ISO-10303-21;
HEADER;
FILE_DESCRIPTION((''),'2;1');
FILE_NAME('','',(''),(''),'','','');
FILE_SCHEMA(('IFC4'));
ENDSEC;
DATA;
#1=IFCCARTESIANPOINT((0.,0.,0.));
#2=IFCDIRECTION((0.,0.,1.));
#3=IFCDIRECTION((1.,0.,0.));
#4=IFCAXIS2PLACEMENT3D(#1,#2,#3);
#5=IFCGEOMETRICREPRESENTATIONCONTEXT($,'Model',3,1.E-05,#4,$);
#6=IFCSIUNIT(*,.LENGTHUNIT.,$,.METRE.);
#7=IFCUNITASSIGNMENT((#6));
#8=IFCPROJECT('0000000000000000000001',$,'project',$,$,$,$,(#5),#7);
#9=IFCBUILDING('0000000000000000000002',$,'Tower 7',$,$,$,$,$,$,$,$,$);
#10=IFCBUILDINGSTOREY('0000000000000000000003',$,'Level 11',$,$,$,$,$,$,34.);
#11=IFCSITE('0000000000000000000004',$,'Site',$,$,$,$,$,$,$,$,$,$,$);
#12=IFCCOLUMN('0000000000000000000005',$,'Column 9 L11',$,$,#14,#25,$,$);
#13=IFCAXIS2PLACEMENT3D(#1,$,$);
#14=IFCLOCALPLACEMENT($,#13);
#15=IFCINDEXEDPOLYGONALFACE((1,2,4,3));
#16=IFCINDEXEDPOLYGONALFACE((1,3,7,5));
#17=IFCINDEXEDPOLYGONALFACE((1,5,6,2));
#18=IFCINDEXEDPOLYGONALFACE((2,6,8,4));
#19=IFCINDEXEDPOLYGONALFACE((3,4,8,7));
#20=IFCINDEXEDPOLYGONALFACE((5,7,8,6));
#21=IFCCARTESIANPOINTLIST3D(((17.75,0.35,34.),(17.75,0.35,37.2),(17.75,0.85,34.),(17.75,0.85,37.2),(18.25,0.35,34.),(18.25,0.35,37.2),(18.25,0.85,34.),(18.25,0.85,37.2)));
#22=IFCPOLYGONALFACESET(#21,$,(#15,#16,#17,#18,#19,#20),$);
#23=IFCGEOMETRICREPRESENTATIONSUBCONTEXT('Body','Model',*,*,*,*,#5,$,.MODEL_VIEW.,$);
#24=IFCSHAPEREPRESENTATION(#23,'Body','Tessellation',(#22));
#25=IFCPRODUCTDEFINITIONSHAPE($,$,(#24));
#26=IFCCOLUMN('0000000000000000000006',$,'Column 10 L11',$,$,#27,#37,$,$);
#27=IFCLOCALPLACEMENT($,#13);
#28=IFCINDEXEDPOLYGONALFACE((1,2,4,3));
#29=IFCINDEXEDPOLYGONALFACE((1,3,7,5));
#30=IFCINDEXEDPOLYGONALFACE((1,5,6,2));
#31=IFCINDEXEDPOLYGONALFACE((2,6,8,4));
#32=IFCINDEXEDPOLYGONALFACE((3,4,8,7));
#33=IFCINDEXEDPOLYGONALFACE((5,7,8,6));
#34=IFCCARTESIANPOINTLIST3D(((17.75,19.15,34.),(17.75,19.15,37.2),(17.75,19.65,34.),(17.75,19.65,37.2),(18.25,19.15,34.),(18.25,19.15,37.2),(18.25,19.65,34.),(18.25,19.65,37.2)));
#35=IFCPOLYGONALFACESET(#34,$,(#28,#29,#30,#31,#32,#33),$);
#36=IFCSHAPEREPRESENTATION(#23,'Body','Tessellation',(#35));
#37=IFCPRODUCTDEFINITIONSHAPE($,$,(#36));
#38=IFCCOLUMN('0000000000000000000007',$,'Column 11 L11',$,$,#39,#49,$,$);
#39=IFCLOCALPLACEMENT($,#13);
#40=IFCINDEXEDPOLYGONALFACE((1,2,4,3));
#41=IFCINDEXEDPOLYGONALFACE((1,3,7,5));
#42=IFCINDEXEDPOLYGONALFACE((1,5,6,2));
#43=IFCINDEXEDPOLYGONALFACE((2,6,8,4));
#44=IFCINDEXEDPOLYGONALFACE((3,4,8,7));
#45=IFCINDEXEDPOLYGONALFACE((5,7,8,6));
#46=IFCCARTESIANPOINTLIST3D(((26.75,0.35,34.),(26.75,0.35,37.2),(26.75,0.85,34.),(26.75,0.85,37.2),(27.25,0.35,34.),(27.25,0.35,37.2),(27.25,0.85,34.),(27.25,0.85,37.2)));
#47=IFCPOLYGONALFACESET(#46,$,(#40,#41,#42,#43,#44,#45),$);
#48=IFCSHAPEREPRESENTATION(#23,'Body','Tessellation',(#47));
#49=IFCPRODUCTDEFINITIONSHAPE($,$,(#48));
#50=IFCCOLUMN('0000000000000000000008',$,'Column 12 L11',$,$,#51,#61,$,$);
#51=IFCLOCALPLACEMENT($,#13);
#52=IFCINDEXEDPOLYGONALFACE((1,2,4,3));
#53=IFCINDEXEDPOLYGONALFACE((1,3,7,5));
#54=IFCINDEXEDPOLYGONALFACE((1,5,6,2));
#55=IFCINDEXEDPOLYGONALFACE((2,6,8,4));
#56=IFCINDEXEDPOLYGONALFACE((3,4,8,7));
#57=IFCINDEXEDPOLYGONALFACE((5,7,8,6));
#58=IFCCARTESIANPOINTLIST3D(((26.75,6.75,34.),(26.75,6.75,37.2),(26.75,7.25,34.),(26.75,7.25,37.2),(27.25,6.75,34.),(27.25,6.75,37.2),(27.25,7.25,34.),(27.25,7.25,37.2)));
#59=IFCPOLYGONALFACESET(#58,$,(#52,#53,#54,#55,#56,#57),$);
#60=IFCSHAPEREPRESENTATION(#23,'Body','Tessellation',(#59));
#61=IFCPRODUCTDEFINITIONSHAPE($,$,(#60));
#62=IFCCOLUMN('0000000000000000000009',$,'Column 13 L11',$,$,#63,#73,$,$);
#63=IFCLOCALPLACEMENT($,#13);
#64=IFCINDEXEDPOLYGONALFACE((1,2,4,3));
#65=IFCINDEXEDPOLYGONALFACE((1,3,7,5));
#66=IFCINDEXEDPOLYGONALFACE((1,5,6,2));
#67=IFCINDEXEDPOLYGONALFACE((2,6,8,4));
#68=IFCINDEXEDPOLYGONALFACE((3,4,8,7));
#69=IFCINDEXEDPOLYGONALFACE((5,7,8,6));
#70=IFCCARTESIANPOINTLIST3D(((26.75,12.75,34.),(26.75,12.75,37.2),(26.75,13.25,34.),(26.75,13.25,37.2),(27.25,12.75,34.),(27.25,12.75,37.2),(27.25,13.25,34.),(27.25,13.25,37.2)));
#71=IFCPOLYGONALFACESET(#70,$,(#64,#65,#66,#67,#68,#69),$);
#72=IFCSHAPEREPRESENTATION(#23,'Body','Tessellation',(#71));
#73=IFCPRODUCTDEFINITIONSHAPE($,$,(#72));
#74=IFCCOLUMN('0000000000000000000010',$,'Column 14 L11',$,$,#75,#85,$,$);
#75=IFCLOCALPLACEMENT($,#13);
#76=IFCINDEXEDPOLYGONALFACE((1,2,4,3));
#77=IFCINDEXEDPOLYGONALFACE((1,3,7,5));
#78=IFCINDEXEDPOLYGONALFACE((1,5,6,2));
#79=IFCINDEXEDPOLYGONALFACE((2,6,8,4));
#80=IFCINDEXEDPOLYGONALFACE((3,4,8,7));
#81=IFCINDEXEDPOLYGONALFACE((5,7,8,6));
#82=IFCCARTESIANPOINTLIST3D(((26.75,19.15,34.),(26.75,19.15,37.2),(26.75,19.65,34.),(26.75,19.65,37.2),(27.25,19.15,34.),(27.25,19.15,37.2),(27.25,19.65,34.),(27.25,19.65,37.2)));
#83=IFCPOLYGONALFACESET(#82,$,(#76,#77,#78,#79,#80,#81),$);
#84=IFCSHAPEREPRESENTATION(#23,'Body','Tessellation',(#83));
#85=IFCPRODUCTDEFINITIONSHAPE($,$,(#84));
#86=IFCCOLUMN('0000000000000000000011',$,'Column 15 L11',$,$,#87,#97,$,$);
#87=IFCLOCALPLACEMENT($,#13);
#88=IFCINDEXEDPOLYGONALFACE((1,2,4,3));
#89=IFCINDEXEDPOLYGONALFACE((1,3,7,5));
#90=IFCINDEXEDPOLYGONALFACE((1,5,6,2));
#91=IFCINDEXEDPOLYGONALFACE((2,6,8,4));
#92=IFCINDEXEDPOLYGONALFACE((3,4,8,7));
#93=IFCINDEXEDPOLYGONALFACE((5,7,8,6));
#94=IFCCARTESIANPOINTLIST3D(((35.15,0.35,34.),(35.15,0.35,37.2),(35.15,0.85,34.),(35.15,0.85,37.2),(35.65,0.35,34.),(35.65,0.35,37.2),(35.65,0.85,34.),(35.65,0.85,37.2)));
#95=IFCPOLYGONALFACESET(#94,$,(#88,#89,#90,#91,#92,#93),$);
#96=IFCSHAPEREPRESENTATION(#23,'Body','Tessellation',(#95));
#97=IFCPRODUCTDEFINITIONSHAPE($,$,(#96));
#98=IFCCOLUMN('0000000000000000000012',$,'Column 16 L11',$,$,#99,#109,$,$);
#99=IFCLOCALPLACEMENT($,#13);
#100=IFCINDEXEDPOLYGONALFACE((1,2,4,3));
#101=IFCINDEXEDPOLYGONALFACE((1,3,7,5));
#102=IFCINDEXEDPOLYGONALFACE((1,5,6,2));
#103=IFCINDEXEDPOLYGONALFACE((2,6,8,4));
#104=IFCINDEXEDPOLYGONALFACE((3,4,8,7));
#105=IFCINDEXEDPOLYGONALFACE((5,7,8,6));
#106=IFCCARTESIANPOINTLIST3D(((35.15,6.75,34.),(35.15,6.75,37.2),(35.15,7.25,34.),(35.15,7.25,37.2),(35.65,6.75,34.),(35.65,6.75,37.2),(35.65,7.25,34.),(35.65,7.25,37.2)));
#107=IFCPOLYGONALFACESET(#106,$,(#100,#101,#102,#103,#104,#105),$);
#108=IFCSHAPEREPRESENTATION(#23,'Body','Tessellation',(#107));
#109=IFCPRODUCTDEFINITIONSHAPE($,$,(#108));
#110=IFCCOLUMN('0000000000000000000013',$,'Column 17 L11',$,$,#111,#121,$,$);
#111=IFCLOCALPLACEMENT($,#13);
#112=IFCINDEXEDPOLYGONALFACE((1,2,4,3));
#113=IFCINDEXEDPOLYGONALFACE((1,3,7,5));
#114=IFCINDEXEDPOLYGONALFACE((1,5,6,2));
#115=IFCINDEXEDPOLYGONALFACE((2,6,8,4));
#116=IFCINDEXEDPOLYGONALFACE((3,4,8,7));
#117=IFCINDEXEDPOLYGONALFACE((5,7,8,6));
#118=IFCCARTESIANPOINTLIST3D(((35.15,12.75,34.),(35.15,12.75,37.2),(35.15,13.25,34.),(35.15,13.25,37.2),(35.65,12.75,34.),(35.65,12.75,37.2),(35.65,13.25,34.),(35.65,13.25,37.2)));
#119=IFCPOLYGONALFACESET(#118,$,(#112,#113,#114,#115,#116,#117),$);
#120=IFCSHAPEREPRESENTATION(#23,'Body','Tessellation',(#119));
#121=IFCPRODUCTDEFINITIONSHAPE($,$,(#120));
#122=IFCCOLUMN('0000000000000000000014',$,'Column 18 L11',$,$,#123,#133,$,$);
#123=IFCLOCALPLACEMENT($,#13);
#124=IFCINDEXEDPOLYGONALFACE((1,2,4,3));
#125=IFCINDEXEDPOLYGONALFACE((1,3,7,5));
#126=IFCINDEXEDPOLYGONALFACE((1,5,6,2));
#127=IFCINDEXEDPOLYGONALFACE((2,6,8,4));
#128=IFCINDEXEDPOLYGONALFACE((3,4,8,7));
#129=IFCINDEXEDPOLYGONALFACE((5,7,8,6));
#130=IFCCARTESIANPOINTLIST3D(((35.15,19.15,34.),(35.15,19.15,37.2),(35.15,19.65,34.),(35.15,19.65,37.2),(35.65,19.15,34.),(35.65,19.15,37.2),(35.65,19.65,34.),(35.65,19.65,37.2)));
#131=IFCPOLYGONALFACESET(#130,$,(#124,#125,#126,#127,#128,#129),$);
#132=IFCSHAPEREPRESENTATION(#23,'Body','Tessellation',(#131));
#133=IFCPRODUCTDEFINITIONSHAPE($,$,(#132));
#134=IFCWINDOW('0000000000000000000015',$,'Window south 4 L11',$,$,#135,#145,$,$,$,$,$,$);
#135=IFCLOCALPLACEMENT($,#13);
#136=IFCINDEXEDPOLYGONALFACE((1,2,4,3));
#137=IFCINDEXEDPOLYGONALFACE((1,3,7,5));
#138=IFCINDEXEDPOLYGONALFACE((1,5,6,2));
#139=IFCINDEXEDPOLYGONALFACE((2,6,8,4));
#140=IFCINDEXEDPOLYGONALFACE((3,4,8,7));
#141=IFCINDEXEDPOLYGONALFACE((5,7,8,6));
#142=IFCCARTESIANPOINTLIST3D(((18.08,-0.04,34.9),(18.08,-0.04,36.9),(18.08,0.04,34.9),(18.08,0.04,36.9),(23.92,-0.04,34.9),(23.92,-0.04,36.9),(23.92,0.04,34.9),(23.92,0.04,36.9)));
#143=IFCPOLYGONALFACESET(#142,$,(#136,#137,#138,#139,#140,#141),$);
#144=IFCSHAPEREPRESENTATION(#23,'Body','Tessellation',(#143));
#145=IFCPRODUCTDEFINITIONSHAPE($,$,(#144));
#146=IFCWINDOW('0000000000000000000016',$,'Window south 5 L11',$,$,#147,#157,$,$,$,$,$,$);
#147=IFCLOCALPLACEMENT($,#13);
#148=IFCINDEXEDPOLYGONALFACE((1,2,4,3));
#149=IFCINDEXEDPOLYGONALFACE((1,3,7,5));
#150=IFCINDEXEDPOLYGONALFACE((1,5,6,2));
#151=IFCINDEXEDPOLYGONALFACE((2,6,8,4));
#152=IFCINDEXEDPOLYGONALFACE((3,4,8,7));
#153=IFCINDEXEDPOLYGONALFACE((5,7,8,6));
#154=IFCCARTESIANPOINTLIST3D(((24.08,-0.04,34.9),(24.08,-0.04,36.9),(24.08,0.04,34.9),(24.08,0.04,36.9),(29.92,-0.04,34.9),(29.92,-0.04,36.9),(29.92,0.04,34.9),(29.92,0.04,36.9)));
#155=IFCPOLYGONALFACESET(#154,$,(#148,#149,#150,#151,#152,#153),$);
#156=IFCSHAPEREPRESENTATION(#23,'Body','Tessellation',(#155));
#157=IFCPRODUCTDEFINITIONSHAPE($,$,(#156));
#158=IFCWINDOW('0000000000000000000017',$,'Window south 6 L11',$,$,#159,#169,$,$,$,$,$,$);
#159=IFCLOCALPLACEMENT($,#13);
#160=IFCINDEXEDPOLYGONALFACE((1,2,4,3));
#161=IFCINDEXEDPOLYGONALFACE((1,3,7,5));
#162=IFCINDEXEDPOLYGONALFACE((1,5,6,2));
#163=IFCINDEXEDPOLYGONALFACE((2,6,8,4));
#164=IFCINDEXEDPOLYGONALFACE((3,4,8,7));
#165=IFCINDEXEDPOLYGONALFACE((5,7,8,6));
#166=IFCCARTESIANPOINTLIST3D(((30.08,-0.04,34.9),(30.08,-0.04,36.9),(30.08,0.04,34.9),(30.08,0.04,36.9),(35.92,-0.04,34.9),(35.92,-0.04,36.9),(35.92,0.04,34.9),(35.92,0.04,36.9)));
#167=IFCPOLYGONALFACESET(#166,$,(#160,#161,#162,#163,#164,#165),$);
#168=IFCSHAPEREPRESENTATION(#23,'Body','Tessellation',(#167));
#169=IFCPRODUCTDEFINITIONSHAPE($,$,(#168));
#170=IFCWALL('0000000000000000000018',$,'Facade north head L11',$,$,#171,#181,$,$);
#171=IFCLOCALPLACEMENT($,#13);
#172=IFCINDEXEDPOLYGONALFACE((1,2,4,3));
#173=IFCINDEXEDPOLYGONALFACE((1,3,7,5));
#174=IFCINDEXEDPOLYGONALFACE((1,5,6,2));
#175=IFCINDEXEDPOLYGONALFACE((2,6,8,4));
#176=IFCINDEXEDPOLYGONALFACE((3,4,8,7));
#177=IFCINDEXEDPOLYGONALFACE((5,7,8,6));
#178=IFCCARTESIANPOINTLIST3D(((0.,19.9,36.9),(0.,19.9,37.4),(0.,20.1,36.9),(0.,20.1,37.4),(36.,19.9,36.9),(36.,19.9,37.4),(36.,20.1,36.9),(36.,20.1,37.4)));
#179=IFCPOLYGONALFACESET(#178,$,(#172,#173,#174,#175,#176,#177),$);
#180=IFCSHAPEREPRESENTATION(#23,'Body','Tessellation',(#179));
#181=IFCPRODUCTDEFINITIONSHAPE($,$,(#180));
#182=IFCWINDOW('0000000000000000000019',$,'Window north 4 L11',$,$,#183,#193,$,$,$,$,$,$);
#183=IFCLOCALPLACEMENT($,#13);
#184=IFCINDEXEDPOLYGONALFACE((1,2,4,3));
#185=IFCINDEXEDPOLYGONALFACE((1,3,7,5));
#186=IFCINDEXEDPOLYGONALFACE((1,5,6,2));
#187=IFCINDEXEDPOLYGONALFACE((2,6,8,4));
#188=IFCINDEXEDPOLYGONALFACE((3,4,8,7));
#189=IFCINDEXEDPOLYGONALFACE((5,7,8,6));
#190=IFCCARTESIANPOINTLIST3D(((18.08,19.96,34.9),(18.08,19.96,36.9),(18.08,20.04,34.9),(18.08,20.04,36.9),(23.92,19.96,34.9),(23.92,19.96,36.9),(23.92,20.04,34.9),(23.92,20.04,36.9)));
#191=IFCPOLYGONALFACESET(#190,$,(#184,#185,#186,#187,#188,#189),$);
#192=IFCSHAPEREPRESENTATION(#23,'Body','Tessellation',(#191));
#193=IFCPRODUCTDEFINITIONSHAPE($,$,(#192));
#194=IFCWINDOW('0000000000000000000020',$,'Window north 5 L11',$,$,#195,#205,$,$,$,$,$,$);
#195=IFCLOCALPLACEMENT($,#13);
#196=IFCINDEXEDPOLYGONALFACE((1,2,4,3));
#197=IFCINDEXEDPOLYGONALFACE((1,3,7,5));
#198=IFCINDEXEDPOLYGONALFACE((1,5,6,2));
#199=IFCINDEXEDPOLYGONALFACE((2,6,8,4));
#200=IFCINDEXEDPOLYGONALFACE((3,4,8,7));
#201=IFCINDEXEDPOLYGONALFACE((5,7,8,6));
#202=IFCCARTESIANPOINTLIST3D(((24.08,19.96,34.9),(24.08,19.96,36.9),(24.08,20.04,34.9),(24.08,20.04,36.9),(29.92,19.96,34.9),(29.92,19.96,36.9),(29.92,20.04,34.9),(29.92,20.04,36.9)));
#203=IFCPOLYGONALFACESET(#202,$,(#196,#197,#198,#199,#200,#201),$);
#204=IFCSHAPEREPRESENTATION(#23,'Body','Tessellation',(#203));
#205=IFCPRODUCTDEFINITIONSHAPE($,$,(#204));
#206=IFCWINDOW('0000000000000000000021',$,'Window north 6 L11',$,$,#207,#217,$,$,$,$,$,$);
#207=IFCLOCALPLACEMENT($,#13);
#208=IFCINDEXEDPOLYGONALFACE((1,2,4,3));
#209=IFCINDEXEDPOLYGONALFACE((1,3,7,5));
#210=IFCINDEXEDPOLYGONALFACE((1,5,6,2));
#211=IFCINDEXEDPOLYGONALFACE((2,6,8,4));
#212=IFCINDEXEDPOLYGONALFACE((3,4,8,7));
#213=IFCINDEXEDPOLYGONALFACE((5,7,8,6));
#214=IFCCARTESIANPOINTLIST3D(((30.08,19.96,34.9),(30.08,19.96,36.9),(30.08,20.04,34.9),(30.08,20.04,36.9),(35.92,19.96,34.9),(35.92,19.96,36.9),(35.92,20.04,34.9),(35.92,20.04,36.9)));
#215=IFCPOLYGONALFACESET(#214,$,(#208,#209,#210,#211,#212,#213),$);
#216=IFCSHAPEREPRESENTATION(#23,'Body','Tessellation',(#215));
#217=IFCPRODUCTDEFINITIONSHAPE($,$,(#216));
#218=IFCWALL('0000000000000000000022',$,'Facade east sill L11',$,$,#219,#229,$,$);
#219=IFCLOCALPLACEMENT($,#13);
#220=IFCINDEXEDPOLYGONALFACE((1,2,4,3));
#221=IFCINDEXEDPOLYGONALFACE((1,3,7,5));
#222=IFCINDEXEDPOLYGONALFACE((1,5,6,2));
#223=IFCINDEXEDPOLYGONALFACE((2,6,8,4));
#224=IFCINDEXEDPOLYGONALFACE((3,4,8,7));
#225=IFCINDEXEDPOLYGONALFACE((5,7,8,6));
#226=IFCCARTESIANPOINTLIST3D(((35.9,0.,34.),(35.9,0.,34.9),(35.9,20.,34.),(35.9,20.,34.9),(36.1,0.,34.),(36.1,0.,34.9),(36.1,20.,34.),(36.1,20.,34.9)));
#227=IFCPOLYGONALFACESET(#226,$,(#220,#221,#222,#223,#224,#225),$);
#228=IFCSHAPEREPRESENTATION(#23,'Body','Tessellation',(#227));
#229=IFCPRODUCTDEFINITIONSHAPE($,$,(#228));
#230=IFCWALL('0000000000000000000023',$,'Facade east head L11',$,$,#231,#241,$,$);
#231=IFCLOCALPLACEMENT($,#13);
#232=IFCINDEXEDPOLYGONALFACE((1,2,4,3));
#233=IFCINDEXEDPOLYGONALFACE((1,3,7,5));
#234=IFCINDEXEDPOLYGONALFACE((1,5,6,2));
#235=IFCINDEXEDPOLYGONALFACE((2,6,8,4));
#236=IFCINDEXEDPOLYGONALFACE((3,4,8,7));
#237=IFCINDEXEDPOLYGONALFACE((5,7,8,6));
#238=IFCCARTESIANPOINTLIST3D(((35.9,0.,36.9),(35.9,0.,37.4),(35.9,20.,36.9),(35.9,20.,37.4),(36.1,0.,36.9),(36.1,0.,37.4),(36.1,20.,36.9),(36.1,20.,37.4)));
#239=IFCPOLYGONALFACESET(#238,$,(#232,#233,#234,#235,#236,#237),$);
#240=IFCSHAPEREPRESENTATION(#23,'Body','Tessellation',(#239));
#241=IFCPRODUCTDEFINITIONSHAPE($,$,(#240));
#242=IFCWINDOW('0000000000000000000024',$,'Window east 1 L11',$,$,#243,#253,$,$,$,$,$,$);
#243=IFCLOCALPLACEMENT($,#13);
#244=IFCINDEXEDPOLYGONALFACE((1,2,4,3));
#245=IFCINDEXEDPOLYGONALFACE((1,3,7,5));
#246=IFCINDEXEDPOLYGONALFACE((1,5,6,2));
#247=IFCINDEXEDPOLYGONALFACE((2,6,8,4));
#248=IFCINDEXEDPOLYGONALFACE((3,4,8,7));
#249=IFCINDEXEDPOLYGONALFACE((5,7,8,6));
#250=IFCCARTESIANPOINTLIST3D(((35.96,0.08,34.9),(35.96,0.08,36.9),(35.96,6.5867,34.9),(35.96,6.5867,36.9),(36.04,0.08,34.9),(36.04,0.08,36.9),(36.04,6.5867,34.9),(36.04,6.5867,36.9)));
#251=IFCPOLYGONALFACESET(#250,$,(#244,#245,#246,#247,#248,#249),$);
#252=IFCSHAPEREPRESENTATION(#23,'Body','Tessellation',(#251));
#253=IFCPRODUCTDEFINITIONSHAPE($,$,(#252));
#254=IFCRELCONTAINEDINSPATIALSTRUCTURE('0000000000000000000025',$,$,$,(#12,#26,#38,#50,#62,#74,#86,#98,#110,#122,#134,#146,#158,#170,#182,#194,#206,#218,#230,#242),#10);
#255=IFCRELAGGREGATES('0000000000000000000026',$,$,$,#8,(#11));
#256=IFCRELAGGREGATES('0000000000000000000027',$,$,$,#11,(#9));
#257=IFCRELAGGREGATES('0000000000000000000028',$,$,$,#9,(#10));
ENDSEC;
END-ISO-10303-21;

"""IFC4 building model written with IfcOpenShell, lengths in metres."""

from ifc_helpers import new_model, si_unit, frame, origin, origin_with_axes, origin_2d, place, context, subcontext, project, spatial, rectangle, extrude, element, save


model = new_model("IFC4")

# Units and contexts
model_context = context("Model", 3, precision=1e-05, world=origin_with_axes())
body_context = subcontext(model_context, "Body", "Model", "MODEL_VIEW")
ifc_project = project(units=[si_unit("LENGTHUNIT", "METRE")], contexts=[model_context])

# Site, building, storey
site = spatial("IfcSite", under=ifc_project, Name="Site")
building = spatial("IfcBuilding", under=site, Name="Tower 7")
storey = spatial("IfcBuildingStorey", under=building, Name="Level 11", Elevation=34.0)

# Columns
for number, where, z_axis, x_axis, name in (
    (1, (18.0, 0.6, 34.0), (0.0, 0.0, 1.0), (1.0, 0.0, 0.0), "Column 9 L11"),
    (2, (18.0, 19.4, 34.0), (0.0, 0.0, 1.0), (1.0, 0.0, 0.0), "Column 10 L11"),
    (3, (27.0, 0.6, 34.0), (0.0, 0.0, 1.0), (1.0, 0.0, 0.0), "Column 11 L11"),
    (4, (27.0, 7.0, 34.0), (0.0, 0.0, 1.0), (1.0, 0.0, 0.0), "Column 12 L11"),
    (5, (27.0, 13.0, 34.0), (0.0, 0.0, 1.0), (1.0, 0.0, 0.0), "Column 13 L11"),
    (6, (27.0, 19.4, 34.0), (0.0, 0.0, 1.0), (1.0, 0.0, 0.0), "Column 14 L11"),
    (7, (35.4, 0.6, 34.0), (0.0, 0.0, 1.0), (1.0, 0.0, 0.0), "Column 15 L11"),
    (8, (35.4, 7.0, 34.0), (0.0, 0.0, 1.0), (1.0, 0.0, 0.0), "Column 16 L11"),
    (9, (35.4, 13.0, 34.0), (0.0, 0.0, 1.0), (1.0, 0.0, 0.0), "Column 17 L11"),
    (10, (35.4, 19.4, 34.0), (0.0, 0.0, 1.0), (1.0, 0.0, 0.0), "Column 18 L11"),
):
    element("IfcColumn", number, at=place(None, frame(where, z_axis=z_axis, x_axis=x_axis)), inside=storey, Name=name, context=body_context, shape_type="SweptSolid", body=[
        extrude(rectangle(XDim=0.5, YDim=0.5, at=origin_2d()), origin(), (0.0, 0.0, 1.0), 3.2),
    ])

# Windows
for number, where, z_axis, x_axis, name in (
    (11, (21.0, 0.0, 34.9), (0.0, 0.0, 1.0), (1.0, 0.0, 0.0), "Window south 4 L11"),
    (12, (27.0, 0.0, 34.9), (0.0, 0.0, 1.0), (1.0, 0.0, 0.0), "Window south 5 L11"),
    (13, (33.0, 0.0, 34.9), (0.0, 0.0, 1.0), (1.0, 0.0, 0.0), "Window south 6 L11"),
):
    element("IfcWindow", number, at=place(None, frame(where, z_axis=z_axis, x_axis=x_axis)), inside=storey, Name=name, context=body_context, shape_type="SweptSolid", body=[
        extrude(rectangle(XDim=5.84, YDim=0.08, at=origin_2d()), origin(), (0.0, 0.0, 1.0), 2.0),
    ])

# Wall
wall_1_placement = place(None, frame((18.0, 20.0, 36.9), z_axis=(0.0, 0.0, 1.0), x_axis=(1.0, 0.0, 0.0)))
element("IfcWall", 14, at=wall_1_placement, inside=storey, Name="Facade north head L11", context=body_context, shape_type="SweptSolid", body=[
    extrude(rectangle(XDim=36.0, YDim=0.2, at=origin_2d()), origin(), (0.0, 0.0, 1.0), 0.5),
])

# Windows
for number, where, z_axis, x_axis, name in (
    (15, (21.0, 20.0, 34.9), (0.0, 0.0, 1.0), (1.0, 0.0, 0.0), "Window north 4 L11"),
    (16, (27.0, 20.0, 34.9), (0.0, 0.0, 1.0), (1.0, 0.0, 0.0), "Window north 5 L11"),
    (17, (33.0, 20.0, 34.9), (0.0, 0.0, 1.0), (1.0, 0.0, 0.0), "Window north 6 L11"),
):
    element("IfcWindow", number, at=place(None, frame(where, z_axis=z_axis, x_axis=x_axis)), inside=storey, Name=name, context=body_context, shape_type="SweptSolid", body=[
        extrude(rectangle(XDim=5.84, YDim=0.08, at=origin_2d()), origin(), (0.0, 0.0, 1.0), 2.0),
    ])

# Walls
wall_2_placement = place(None, frame((36.0, 10.0, 34.0), z_axis=(0.0, 0.0, 1.0), x_axis=(1.0, 0.0, 0.0)))
element("IfcWall", 18, at=wall_2_placement, inside=storey, Name="Facade east sill L11", context=body_context, shape_type="SweptSolid", body=[
    extrude(rectangle(XDim=0.2, YDim=20.0, at=origin_2d()), origin(), (0.0, 0.0, 1.0), 0.9),
])
wall_3_placement = place(None, frame((36.0, 10.0, 36.9), z_axis=(0.0, 0.0, 1.0), x_axis=(1.0, 0.0, 0.0)))
element("IfcWall", 19, at=wall_3_placement, inside=storey, Name="Facade east head L11", context=body_context, shape_type="SweptSolid", body=[
    extrude(rectangle(XDim=0.2, YDim=20.0, at=origin_2d()), origin(), (0.0, 0.0, 1.0), 0.5),
])

# Window
for number, where, z_axis, x_axis, name in (
    (20, (36.0, 3.3333, 34.9), (0.0, 0.0, 1.0), (1.0, 0.0, 0.0), "Window east 1 L11"),
):
    element("IfcWindow", number, at=place(None, frame(where, z_axis=z_axis, x_axis=x_axis)), inside=storey, Name=name, context=body_context, shape_type="SweptSolid", body=[
        extrude(rectangle(XDim=0.08, YDim=6.5067, at=origin_2d()), origin(), (0.0, 0.0, 1.0), 2.0),
    ])

save(model, "model.ifc")
